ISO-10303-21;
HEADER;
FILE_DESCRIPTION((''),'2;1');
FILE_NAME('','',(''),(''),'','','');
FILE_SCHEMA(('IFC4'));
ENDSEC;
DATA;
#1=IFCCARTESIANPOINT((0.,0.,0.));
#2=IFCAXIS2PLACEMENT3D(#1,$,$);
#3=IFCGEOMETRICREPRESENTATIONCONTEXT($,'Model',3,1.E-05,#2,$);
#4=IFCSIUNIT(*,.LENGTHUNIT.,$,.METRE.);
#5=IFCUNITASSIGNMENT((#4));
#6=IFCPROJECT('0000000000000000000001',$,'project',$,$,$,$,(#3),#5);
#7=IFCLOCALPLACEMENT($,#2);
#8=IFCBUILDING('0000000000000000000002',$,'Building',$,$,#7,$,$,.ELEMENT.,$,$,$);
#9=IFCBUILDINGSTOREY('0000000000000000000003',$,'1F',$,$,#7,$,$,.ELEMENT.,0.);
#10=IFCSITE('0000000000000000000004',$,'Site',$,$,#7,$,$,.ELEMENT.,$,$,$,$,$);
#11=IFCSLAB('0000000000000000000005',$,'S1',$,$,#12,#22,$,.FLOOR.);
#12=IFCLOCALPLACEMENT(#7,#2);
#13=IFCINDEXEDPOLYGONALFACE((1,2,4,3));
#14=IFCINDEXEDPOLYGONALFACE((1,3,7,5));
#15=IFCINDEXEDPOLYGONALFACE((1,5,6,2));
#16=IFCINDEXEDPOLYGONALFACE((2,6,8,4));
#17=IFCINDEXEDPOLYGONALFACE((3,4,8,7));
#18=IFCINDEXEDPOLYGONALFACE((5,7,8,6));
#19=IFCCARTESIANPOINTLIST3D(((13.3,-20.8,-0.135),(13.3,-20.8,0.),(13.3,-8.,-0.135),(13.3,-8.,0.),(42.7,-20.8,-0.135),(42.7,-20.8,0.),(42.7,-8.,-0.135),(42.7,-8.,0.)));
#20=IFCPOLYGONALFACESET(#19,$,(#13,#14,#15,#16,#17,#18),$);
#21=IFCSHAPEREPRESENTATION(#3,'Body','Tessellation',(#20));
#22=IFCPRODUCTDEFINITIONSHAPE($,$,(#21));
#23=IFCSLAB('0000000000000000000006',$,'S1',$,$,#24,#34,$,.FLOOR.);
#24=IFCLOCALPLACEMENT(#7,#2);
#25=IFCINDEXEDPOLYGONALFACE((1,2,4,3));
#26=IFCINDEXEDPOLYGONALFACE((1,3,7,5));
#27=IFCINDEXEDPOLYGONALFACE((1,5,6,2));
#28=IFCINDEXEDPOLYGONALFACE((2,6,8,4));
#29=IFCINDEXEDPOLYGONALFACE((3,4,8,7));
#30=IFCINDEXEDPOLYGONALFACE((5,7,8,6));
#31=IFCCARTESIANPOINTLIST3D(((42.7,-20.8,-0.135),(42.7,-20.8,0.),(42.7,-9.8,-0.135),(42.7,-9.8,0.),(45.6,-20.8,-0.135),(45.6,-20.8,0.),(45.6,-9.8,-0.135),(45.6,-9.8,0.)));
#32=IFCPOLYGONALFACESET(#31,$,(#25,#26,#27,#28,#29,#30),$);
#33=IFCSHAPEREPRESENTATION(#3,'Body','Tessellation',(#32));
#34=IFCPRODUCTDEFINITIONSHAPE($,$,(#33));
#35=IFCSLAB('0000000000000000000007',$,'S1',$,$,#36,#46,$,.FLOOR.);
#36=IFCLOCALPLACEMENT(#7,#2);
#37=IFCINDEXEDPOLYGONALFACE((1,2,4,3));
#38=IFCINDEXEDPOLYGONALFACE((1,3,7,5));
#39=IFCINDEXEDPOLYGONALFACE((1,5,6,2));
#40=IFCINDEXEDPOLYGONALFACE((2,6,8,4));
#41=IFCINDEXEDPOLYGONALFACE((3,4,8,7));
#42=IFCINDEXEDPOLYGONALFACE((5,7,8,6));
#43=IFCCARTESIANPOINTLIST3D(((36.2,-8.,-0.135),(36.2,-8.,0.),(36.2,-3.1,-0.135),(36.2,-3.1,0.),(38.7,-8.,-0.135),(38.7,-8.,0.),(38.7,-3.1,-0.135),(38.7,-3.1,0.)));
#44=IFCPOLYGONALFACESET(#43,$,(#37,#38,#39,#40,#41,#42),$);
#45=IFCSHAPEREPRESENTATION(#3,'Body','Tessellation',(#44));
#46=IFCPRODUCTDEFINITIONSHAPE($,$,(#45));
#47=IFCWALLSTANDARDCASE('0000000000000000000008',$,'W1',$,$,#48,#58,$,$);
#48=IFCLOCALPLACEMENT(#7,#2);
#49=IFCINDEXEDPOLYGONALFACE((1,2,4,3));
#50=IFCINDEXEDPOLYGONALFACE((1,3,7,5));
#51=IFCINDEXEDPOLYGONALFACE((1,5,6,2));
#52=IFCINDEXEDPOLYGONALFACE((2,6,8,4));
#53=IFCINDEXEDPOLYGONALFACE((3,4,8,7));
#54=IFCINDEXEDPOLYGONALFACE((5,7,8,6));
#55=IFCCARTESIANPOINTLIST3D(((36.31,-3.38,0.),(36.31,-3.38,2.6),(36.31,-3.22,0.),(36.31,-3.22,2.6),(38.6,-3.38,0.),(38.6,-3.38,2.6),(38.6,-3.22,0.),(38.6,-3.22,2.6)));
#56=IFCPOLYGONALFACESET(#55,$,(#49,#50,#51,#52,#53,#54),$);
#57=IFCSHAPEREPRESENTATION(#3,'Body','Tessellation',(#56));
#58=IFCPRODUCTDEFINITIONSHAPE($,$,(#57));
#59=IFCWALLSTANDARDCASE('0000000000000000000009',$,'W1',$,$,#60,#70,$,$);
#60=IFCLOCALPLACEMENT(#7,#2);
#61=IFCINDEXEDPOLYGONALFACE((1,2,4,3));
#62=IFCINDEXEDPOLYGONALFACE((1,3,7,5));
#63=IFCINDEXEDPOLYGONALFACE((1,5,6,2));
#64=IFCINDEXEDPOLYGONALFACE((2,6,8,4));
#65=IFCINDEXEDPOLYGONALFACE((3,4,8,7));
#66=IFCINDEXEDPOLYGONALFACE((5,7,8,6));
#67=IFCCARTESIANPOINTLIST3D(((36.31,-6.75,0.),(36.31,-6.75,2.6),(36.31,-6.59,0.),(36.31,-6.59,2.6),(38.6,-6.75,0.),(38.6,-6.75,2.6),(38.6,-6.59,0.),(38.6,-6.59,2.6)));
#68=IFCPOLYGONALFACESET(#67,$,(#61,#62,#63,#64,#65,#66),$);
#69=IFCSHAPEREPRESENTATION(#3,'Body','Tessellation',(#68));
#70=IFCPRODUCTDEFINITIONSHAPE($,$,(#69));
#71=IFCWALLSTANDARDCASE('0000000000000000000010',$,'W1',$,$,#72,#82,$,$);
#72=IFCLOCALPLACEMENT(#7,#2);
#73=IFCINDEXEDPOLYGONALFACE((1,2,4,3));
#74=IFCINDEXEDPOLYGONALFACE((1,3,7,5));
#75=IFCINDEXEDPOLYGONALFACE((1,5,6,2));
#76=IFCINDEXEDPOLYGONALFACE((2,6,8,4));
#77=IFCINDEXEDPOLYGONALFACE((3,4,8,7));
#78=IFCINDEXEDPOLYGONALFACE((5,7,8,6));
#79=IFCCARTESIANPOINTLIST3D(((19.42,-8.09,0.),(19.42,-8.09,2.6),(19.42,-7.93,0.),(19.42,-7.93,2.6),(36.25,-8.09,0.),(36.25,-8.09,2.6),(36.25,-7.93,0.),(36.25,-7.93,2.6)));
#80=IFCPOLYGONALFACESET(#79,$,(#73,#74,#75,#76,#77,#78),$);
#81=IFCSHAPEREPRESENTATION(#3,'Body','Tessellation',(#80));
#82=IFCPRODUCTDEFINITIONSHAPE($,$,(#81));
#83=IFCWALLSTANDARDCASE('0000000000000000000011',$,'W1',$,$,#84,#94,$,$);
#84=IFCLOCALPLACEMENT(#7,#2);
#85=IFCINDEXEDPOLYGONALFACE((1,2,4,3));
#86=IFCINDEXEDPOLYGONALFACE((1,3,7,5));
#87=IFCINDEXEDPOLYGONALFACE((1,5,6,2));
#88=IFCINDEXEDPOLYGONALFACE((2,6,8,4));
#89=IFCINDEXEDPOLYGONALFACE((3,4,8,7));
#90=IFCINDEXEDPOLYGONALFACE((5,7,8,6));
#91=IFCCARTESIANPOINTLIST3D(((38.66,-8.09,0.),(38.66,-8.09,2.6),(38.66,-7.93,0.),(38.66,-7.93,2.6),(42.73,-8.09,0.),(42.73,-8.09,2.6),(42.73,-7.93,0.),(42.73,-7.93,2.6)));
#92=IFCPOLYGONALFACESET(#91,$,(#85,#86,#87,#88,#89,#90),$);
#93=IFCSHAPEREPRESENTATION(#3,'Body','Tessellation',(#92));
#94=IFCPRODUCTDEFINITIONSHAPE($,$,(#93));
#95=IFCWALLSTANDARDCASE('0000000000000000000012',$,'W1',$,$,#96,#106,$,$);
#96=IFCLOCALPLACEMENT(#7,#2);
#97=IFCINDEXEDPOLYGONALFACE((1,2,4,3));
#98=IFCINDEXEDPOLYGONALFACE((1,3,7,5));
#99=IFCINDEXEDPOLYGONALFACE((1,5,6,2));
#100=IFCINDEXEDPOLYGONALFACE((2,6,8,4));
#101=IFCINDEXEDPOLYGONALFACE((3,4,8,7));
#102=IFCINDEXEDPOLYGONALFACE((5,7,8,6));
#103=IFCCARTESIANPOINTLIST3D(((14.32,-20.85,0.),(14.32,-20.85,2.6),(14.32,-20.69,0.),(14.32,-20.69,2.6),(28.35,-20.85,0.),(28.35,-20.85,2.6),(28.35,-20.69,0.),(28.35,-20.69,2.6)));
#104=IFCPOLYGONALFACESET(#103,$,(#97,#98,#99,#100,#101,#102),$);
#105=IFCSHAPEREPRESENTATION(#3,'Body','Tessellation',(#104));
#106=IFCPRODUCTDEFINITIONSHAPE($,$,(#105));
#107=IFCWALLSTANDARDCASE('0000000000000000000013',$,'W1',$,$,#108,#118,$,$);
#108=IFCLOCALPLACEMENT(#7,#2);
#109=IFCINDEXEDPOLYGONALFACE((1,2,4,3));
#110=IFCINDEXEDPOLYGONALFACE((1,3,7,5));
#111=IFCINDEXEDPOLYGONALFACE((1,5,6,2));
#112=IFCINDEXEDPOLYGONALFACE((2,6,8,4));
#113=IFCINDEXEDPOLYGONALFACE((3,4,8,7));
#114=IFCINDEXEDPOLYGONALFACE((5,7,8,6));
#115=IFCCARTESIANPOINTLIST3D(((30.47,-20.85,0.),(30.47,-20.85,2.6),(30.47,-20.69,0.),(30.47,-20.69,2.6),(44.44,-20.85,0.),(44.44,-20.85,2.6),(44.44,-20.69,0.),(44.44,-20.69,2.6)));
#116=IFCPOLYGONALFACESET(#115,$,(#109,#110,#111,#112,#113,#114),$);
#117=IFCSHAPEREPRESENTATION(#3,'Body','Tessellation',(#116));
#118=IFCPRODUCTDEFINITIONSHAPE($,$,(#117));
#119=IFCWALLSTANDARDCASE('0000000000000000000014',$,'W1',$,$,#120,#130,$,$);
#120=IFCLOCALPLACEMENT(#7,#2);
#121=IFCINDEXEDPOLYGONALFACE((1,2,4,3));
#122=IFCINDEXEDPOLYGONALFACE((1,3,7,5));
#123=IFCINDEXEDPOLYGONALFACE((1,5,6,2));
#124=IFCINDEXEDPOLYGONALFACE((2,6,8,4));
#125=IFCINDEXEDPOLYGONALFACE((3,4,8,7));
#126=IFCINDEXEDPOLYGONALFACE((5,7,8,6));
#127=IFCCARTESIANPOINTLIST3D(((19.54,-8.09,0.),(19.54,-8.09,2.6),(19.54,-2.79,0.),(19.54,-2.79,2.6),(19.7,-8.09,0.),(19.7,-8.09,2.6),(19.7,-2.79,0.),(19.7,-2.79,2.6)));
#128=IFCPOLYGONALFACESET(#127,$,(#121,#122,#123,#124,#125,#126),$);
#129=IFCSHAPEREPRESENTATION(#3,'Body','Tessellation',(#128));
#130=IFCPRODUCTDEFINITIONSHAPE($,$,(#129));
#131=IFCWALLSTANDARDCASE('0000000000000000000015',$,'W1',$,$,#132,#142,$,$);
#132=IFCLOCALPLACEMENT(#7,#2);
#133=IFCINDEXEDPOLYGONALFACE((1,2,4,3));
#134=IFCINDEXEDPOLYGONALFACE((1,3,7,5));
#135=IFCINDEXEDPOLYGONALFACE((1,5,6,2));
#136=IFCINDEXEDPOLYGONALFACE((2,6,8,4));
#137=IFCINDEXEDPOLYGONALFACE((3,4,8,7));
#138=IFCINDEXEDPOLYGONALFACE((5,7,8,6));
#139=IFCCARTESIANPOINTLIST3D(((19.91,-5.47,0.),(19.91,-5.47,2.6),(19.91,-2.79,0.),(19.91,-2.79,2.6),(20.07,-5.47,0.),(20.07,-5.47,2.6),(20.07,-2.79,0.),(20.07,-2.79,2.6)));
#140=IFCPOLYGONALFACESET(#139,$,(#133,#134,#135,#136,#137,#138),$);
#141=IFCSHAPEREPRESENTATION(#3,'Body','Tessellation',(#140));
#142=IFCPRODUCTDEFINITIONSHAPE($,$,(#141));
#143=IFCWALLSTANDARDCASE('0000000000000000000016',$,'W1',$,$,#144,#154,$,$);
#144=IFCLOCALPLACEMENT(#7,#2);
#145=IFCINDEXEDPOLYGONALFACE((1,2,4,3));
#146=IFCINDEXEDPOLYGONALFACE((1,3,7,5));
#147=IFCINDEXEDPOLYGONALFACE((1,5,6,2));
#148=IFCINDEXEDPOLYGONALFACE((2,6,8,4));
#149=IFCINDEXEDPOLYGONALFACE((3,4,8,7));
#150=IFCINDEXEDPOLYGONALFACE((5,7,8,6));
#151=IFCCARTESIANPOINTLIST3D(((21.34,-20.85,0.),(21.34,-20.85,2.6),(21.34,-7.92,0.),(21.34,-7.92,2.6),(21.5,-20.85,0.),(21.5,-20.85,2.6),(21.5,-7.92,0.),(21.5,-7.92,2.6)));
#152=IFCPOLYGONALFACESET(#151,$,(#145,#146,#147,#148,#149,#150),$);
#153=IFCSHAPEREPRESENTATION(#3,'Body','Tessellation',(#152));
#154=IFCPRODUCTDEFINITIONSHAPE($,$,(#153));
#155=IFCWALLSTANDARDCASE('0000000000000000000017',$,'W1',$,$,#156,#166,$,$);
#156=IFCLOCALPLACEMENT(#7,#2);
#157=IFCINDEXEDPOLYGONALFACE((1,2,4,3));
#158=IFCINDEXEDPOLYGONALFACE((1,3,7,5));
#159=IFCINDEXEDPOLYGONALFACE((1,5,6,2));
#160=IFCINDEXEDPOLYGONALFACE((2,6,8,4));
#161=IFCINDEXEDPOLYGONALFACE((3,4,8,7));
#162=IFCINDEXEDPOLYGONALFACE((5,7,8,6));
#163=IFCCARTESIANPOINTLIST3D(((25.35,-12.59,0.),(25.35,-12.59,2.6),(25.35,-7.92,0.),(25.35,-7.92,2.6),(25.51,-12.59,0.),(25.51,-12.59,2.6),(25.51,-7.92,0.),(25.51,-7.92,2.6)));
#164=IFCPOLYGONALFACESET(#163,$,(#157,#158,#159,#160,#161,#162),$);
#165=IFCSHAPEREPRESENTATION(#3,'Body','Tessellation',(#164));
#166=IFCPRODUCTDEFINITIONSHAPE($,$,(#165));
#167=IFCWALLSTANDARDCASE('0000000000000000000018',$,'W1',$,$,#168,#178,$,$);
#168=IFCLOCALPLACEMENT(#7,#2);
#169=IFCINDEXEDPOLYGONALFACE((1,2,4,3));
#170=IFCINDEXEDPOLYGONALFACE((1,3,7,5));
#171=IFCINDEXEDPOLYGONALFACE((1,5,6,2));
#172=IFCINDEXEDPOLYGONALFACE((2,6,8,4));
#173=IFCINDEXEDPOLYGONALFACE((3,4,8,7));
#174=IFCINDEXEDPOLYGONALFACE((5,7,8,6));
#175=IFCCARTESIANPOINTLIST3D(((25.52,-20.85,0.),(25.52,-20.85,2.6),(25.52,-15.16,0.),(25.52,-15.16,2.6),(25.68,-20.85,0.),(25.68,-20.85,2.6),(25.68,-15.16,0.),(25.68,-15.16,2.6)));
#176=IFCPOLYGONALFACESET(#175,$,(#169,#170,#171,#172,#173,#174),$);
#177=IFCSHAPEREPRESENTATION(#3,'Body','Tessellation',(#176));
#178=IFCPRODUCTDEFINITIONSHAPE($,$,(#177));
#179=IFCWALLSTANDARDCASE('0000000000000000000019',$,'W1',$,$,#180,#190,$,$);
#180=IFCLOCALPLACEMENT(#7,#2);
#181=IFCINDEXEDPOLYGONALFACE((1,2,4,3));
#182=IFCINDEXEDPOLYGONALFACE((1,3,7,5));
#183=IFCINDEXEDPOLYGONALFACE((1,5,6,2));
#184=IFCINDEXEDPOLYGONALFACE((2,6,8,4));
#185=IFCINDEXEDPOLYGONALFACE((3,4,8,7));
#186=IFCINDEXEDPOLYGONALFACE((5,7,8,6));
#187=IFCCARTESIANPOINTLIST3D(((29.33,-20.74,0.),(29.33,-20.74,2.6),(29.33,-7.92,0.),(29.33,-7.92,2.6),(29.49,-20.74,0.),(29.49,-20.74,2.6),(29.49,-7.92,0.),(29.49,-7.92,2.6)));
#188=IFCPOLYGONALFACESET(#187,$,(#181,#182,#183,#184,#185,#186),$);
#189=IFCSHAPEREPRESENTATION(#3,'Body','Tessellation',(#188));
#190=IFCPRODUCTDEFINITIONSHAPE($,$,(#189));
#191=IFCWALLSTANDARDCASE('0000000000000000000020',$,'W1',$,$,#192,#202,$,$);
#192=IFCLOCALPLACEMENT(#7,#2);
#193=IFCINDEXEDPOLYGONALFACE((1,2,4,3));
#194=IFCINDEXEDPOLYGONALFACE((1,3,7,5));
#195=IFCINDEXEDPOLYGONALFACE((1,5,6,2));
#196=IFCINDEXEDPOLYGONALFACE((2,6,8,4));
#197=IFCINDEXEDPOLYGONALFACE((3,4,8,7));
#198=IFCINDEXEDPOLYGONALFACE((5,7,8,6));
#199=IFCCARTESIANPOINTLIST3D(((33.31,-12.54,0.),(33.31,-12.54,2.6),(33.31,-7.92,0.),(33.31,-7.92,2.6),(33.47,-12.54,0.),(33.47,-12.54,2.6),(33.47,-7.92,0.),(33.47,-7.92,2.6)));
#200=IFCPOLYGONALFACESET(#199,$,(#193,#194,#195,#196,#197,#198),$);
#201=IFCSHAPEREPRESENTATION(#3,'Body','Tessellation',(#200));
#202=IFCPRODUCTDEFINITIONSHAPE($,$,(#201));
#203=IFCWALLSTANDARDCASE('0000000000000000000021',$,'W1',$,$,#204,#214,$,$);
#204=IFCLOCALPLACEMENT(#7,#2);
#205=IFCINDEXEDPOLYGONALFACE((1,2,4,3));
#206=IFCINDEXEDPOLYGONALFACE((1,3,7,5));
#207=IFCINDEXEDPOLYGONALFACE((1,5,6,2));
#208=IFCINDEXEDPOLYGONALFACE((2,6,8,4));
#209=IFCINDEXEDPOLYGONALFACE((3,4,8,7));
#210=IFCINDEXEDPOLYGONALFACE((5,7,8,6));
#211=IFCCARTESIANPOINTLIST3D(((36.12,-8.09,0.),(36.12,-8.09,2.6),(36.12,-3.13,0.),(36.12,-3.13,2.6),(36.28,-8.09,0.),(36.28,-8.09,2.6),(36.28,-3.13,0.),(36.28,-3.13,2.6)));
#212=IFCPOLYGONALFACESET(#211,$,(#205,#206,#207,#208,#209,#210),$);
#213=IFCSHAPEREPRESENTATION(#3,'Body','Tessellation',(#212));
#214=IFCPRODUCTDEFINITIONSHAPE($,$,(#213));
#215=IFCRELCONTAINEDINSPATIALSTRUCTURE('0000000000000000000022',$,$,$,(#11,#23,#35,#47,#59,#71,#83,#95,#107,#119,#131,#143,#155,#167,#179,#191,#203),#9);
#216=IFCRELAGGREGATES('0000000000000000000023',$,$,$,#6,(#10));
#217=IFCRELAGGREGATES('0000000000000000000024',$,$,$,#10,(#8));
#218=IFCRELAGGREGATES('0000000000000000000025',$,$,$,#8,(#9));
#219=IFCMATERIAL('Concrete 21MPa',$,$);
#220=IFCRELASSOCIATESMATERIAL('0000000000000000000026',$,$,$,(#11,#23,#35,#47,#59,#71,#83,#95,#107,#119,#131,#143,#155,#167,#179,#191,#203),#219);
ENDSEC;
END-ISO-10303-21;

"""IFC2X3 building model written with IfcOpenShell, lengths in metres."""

from ifc_helpers import new_model, si_unit, frame, origin, origin_2d, place, context, project, spatial, rectangle, extrude, material, element, save


model = new_model("IFC2X3")

# Units and contexts
model_context = context("Model", 3, precision=1e-05, world=origin())
ifc_project = project(units=[si_unit("LENGTHUNIT", "METRE")], contexts=[model_context])

# Site, building, storey
placement = place(None, origin())
site = spatial("IfcSite", under=ifc_project, at=placement, Name="Site", CompositionType="ELEMENT")
building = spatial("IfcBuilding", under=site, at=placement, Name="Building", CompositionType="ELEMENT")
storey = spatial("IfcBuildingStorey", under=building, at=placement, Name="1F", CompositionType="ELEMENT", Elevation=0.0)

# Slabs
ifc_material_1 = material(Name="Concrete 21MPa")
slab_1_placement = place(None, frame((28.0, -14.4, -0.135)))
element("IfcSlab", 1, at=slab_1_placement, inside=storey, material=ifc_material_1, Name="S1", PredefinedType="FLOOR", context=model_context, shape_type="SweptSolid", body=[
    extrude(rectangle(XDim=29.4, YDim=12.8, at=origin_2d()), origin(), (0.0, 0.0, 1.0), 0.135),
])
slab_2_placement = place(None, frame((44.15, -15.3, -0.135)))
element("IfcSlab", 2, at=slab_2_placement, inside=storey, material=ifc_material_1, Name="S1", PredefinedType="FLOOR", context=model_context, shape_type="SweptSolid", body=[
    extrude(rectangle(XDim=2.9, YDim=11.0, at=origin_2d()), origin(), (0.0, 0.0, 1.0), 0.135),
])
slab_3_placement = place(None, frame((37.45, -5.55, -0.135)))
element("IfcSlab", 3, at=slab_3_placement, inside=storey, material=ifc_material_1, Name="S1", PredefinedType="FLOOR", context=model_context, shape_type="SweptSolid", body=[
    extrude(rectangle(XDim=2.5, YDim=4.9, at=origin_2d()), origin(), (0.0, 0.0, 1.0), 0.135),
])

# Walls
for number, where, name in (
    (4, (37.455, -3.3, 0.0), "W1"),
    (5, (37.455, -6.67, 0.0), "W1"),
):
    element("IfcWallStandardCase", number, at=place(None, frame(where)), inside=storey, material=ifc_material_1, Name=name, context=model_context, shape_type="SweptSolid", body=[
        extrude(rectangle(XDim=2.29, YDim=0.16, at=origin_2d()), origin(), (0.0, 0.0, 1.0), 2.6),
    ])
wall_1_placement = place(None, frame((27.835, -8.01, 0.0)))
element("IfcWallStandardCase", 6, at=wall_1_placement, inside=storey, material=ifc_material_1, Name="W1", context=model_context, shape_type="SweptSolid", body=[
    extrude(rectangle(XDim=16.83, YDim=0.16, at=origin_2d()), origin(), (0.0, 0.0, 1.0), 2.6),
])
wall_2_placement = place(None, frame((40.695, -8.01, 0.0)))
element("IfcWallStandardCase", 7, at=wall_2_placement, inside=storey, material=ifc_material_1, Name="W1", context=model_context, shape_type="SweptSolid", body=[
    extrude(rectangle(XDim=4.07, YDim=0.16, at=origin_2d()), origin(), (0.0, 0.0, 1.0), 2.6),
])
wall_3_placement = place(None, frame((21.335, -20.77, 0.0)))
element("IfcWallStandardCase", 8, at=wall_3_placement, inside=storey, material=ifc_material_1, Name="W1", context=model_context, shape_type="SweptSolid", body=[
    extrude(rectangle(XDim=14.03, YDim=0.16, at=origin_2d()), origin(), (0.0, 0.0, 1.0), 2.6),
])
wall_4_placement = place(None, frame((37.455, -20.77, 0.0)))
element("IfcWallStandardCase", 9, at=wall_4_placement, inside=storey, material=ifc_material_1, Name="W1", context=model_context, shape_type="SweptSolid", body=[
    extrude(rectangle(XDim=13.97, YDim=0.16, at=origin_2d()), origin(), (0.0, 0.0, 1.0), 2.6),
])
wall_5_placement = place(None, frame((19.62, -5.44, 0.0)))
element("IfcWallStandardCase", 10, at=wall_5_placement, inside=storey, material=ifc_material_1, Name="W1", context=model_context, shape_type="SweptSolid", body=[
    extrude(rectangle(XDim=0.16, YDim=5.3, at=origin_2d()), origin(), (0.0, 0.0, 1.0), 2.6),
])
wall_6_placement = place(None, frame((19.99, -4.13, 0.0)))
element("IfcWallStandardCase", 11, at=wall_6_placement, inside=storey, material=ifc_material_1, Name="W1", context=model_context, shape_type="SweptSolid", body=[
    extrude(rectangle(XDim=0.16, YDim=2.68, at=origin_2d()), origin(), (0.0, 0.0, 1.0), 2.6),
])
wall_7_placement = place(None, frame((21.42, -14.385, 0.0)))
element("IfcWallStandardCase", 12, at=wall_7_placement, inside=storey, material=ifc_material_1, Name="W1", context=model_context, shape_type="SweptSolid", body=[
    extrude(rectangle(XDim=0.16, YDim=12.93, at=origin_2d()), origin(), (0.0, 0.0, 1.0), 2.6),
])
wall_8_placement = place(None, frame((25.43, -10.255, 0.0)))
element("IfcWallStandardCase", 13, at=wall_8_placement, inside=storey, material=ifc_material_1, Name="W1", context=model_context, shape_type="SweptSolid", body=[
    extrude(rectangle(XDim=0.16, YDim=4.67, at=origin_2d()), origin(), (0.0, 0.0, 1.0), 2.6),
])
wall_9_placement = place(None, frame((25.6, -18.005, 0.0)))
element("IfcWallStandardCase", 14, at=wall_9_placement, inside=storey, material=ifc_material_1, Name="W1", context=model_context, shape_type="SweptSolid", body=[
    extrude(rectangle(XDim=0.16, YDim=5.69, at=origin_2d()), origin(), (0.0, 0.0, 1.0), 2.6),
])
wall_10_placement = place(None, frame((29.41, -14.33, 0.0)))
element("IfcWallStandardCase", 15, at=wall_10_placement, inside=storey, material=ifc_material_1, Name="W1", context=model_context, shape_type="SweptSolid", body=[
    extrude(rectangle(XDim=0.16, YDim=12.82, at=origin_2d()), origin(), (0.0, 0.0, 1.0), 2.6),
])
wall_11_placement = place(None, frame((33.39, -10.23, 0.0)))
element("IfcWallStandardCase", 16, at=wall_11_placement, inside=storey, material=ifc_material_1, Name="W1", context=model_context, shape_type="SweptSolid", body=[
    extrude(rectangle(XDim=0.16, YDim=4.62, at=origin_2d()), origin(), (0.0, 0.0, 1.0), 2.6),
])
wall_12_placement = place(None, frame((36.2, -5.61, 0.0)))
element("IfcWallStandardCase", 17, at=wall_12_placement, inside=storey, material=ifc_material_1, Name="W1", context=model_context, shape_type="SweptSolid", body=[
    extrude(rectangle(XDim=0.16, YDim=4.96, at=origin_2d()), origin(), (0.0, 0.0, 1.0), 2.6),
])

save(model, "model.ifc")
